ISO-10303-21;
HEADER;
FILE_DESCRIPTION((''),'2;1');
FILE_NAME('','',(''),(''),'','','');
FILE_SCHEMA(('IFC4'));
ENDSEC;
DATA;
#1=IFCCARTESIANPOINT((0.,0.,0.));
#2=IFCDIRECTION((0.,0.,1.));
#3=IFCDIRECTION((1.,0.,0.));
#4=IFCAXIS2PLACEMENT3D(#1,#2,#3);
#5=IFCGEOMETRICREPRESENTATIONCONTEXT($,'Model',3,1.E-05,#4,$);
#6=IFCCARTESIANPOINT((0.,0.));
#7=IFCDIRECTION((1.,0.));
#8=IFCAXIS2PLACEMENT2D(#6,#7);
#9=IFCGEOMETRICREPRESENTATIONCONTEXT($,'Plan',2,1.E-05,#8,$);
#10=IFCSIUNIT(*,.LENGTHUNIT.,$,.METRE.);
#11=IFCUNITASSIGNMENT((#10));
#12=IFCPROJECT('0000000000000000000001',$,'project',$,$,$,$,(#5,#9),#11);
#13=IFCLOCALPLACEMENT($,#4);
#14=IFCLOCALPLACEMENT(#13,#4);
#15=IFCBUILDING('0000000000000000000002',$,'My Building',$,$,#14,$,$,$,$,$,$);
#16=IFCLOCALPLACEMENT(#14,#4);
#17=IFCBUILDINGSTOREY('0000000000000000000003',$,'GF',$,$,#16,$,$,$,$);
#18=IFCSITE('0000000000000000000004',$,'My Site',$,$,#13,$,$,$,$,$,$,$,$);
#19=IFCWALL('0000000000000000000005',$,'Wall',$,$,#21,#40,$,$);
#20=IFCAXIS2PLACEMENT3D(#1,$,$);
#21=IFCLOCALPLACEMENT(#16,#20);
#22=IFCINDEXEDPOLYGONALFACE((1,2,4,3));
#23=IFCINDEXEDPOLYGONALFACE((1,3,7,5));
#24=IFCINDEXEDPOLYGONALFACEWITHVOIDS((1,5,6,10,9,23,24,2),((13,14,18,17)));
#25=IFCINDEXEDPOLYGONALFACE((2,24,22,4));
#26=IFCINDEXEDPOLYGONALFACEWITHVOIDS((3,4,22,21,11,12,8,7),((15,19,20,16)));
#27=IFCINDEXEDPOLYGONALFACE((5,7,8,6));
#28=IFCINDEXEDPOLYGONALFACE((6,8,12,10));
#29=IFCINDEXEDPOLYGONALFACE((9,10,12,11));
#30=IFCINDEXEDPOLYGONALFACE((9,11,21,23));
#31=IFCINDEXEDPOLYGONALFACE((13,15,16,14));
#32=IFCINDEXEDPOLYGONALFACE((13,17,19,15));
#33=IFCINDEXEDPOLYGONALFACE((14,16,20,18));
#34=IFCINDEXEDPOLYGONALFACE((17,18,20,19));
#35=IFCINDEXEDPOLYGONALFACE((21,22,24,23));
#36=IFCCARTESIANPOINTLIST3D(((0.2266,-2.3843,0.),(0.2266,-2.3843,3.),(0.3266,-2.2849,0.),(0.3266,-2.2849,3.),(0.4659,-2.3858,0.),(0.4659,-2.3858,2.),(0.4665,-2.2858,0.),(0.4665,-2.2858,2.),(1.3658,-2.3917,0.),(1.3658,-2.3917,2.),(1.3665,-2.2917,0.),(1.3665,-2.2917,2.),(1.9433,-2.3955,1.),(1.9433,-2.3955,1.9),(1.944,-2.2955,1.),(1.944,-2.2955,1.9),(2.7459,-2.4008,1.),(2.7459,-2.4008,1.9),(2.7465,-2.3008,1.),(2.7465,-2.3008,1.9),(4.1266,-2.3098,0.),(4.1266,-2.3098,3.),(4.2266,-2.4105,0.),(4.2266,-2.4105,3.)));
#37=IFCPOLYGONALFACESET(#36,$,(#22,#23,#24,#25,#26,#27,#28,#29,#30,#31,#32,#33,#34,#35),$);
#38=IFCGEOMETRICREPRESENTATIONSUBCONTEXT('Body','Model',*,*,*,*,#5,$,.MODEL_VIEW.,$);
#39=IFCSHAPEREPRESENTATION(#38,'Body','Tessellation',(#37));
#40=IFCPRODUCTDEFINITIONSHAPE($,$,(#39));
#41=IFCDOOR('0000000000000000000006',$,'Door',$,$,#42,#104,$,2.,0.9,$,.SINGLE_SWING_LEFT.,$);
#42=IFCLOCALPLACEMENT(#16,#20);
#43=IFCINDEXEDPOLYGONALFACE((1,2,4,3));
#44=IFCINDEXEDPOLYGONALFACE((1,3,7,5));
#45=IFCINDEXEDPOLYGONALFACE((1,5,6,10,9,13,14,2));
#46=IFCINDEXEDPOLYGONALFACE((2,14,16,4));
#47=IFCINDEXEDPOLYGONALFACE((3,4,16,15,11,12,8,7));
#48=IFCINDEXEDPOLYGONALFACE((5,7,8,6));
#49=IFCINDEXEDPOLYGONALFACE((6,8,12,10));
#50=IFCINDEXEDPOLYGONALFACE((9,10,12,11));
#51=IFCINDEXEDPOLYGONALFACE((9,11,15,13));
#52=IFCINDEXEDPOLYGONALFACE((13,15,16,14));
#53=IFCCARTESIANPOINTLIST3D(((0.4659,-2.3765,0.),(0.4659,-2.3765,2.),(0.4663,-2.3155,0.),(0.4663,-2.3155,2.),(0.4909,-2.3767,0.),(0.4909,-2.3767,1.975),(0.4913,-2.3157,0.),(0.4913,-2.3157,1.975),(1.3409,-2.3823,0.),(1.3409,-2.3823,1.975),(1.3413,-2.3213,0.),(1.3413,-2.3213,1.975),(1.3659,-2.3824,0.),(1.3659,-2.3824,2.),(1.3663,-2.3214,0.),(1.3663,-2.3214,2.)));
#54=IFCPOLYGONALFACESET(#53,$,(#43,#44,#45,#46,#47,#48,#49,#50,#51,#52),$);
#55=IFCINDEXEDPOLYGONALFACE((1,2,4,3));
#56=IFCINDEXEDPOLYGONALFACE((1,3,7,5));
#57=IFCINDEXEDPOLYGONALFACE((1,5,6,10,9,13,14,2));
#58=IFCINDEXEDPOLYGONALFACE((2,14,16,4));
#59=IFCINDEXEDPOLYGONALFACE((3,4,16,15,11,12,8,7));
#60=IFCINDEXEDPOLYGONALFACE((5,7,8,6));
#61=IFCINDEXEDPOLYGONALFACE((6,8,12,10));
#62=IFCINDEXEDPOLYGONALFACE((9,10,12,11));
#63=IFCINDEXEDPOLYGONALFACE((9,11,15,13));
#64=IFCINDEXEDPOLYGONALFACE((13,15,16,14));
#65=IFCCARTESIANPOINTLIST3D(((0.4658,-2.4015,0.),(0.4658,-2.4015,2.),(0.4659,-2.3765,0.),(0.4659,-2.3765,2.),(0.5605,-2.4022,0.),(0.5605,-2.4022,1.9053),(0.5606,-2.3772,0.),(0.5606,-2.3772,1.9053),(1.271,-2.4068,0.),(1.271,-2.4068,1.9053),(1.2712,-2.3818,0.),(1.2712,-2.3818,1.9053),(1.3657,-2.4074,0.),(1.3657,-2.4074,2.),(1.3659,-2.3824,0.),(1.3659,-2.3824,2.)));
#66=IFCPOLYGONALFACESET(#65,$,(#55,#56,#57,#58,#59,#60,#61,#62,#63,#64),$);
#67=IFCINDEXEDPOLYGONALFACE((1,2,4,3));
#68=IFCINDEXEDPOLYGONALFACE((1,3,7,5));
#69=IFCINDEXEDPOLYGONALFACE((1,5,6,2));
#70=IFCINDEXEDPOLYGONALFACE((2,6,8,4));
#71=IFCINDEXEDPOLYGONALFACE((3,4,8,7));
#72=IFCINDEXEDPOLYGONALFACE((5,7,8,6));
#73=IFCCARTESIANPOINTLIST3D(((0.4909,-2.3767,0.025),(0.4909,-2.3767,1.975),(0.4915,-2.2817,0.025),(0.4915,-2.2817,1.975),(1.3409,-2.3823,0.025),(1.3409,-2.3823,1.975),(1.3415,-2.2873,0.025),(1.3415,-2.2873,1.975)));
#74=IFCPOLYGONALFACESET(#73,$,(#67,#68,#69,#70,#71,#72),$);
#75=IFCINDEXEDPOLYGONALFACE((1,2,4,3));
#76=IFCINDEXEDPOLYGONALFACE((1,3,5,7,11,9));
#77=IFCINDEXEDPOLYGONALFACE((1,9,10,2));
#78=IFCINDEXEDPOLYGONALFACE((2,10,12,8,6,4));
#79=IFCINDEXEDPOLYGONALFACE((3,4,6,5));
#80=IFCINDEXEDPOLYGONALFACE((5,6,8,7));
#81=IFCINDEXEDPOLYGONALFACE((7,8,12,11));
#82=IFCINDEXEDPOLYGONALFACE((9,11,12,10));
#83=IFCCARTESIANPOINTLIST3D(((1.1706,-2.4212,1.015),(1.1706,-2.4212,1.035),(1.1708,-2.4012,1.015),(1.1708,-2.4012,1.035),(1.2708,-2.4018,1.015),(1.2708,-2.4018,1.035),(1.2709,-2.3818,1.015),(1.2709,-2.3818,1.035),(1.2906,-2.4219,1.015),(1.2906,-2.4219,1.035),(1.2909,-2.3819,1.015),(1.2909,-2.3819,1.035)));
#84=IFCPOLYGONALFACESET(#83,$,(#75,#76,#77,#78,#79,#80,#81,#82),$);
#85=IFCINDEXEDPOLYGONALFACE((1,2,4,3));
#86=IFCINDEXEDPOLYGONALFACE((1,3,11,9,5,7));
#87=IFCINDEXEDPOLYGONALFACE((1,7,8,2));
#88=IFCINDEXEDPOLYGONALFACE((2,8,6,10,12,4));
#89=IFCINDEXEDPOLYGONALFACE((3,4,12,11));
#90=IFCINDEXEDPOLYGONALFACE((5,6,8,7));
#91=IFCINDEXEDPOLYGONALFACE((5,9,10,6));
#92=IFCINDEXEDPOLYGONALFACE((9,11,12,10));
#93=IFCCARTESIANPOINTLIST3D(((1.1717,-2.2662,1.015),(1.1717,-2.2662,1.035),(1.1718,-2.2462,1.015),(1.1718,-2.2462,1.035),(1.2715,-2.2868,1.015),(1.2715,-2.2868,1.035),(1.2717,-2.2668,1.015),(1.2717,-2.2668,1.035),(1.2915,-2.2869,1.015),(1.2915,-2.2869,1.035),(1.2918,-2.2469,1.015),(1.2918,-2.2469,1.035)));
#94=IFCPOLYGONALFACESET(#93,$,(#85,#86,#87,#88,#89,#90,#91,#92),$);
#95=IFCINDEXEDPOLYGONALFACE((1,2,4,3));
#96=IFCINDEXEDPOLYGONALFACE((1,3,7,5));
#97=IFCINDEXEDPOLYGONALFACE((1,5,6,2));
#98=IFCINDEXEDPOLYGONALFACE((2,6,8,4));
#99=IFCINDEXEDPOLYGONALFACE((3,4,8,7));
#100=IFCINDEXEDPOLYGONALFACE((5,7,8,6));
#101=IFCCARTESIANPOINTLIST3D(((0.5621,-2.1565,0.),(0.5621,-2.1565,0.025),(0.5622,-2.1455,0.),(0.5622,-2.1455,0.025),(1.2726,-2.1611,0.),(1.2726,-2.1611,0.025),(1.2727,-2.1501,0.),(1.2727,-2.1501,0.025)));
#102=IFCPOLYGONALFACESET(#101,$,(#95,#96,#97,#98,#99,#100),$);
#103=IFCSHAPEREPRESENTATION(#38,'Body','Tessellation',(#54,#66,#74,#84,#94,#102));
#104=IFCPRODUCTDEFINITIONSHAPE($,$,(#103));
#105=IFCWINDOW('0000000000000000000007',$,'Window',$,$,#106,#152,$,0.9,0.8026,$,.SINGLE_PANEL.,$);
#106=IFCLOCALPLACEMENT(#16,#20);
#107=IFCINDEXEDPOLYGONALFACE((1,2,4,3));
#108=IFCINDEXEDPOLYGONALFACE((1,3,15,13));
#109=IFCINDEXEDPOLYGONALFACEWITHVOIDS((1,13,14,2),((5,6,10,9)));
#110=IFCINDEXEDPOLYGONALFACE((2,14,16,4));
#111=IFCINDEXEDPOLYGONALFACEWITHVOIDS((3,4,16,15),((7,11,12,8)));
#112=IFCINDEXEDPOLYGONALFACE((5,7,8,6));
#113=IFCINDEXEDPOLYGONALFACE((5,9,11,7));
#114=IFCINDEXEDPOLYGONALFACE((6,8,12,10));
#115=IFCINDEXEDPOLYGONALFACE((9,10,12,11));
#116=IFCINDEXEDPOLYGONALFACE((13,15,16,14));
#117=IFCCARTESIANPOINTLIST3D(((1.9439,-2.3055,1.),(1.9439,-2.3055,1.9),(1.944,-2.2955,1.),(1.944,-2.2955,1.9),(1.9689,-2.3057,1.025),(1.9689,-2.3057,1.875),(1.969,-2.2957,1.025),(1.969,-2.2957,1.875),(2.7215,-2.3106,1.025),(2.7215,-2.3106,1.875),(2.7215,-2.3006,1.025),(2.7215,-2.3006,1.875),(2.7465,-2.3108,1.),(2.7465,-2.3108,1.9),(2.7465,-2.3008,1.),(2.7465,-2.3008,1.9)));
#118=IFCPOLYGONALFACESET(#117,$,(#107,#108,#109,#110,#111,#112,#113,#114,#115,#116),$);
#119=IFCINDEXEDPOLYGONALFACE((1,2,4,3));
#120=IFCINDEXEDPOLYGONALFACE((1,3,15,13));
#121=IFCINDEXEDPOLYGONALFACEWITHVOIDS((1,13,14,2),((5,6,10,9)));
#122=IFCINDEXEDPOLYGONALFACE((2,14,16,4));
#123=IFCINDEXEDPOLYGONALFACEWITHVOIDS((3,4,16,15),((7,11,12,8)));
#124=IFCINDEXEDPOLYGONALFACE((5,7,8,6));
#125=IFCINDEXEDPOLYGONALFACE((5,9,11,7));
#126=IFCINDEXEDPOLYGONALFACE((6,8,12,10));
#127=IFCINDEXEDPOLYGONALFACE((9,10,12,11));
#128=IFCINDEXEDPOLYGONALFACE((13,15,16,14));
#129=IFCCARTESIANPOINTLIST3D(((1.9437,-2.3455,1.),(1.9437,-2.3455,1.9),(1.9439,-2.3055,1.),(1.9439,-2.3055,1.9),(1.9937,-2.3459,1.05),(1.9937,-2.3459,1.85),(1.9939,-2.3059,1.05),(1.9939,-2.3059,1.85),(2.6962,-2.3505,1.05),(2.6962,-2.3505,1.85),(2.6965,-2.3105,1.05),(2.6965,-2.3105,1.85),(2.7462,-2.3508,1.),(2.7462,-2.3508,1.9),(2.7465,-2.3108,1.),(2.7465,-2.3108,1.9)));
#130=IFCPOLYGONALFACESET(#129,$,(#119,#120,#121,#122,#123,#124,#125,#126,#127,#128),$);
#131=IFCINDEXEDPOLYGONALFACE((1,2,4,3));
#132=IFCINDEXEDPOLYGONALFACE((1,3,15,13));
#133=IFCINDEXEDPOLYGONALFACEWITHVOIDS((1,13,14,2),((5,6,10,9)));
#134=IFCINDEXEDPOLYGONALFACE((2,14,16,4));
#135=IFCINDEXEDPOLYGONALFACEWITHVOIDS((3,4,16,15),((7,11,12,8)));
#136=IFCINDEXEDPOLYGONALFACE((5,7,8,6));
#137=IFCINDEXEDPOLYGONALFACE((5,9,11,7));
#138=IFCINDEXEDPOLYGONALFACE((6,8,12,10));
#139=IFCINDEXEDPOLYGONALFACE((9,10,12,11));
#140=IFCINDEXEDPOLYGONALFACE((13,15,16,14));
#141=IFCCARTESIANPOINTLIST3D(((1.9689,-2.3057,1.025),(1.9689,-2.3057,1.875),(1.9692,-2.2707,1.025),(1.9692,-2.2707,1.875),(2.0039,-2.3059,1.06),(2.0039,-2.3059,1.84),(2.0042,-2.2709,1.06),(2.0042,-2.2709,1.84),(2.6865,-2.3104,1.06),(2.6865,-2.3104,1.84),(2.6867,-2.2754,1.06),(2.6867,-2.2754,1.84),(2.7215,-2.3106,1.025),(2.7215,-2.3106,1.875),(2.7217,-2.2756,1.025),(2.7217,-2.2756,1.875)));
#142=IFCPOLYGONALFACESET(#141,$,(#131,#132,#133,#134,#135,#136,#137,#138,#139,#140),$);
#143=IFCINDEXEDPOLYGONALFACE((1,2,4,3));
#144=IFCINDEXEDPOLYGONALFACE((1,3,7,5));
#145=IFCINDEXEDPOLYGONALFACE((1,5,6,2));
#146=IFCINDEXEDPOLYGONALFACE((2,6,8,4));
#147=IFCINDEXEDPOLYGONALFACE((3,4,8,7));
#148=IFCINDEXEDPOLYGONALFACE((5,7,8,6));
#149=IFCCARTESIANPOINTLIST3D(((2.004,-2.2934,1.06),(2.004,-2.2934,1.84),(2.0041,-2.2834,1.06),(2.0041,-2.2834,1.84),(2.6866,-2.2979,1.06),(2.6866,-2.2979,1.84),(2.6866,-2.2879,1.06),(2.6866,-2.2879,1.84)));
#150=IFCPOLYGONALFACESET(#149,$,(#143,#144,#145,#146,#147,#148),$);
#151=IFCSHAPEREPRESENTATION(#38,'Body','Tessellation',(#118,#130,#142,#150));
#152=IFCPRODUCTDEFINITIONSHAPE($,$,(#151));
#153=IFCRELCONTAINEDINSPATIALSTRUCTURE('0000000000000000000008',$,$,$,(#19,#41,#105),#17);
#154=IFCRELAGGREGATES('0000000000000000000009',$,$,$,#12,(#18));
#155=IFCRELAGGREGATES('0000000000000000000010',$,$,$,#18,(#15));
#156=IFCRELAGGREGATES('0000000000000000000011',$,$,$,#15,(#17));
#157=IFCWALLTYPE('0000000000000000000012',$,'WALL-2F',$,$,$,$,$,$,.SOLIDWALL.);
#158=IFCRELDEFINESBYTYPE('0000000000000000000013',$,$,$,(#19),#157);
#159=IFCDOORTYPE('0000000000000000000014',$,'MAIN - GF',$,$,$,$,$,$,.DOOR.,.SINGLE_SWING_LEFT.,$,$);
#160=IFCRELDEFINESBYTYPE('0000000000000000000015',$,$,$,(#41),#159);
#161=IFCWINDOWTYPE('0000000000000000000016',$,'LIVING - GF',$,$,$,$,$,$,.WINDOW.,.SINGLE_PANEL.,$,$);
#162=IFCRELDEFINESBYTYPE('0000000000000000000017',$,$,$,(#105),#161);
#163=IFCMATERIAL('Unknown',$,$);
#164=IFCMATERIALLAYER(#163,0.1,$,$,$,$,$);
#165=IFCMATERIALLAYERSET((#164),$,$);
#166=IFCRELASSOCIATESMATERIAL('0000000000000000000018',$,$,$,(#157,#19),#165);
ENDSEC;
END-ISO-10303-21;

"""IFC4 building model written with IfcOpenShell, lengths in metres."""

from ifc_helpers import new_model, entity, si_unit, frame, origin_with_axes, origin_2d_with_axis, place, context, subcontext, project, spatial, line, indexed_curve, outline, extrude, shape, source, transform, mapped, material, layer, layer_set, layer_usage, type_object, type_shapes, element, fill, save


model = new_model("IFC4")

# Units and contexts
model_context = context("Model", 3, precision=1e-05, world=origin_with_axes())
plan_context = context("Plan", 2, precision=1e-05, world=origin_2d_with_axis())
body_context_1 = subcontext(model_context, "Body", "Model", "MODEL_VIEW")
body_context_2 = subcontext(plan_context, "Body", "Plan", "PLAN_VIEW")
ifc_project = project(units=[si_unit("LENGTHUNIT", "METRE")], contexts=[model_context, plan_context])

# Site, building, storey
site_placement = place(None, origin_with_axes())
site = spatial("IfcSite", under=ifc_project, at=site_placement, Name="My Site")
building_placement = place(site_placement, origin_with_axes())
building = spatial("IfcBuilding", under=site, at=building_placement, Name="My Building")
storey_placement = place(building_placement, origin_with_axes())
storey = spatial("IfcBuildingStorey", under=building, at=storey_placement, Name="GF")

# Shared definitions
ifc_material = material(Name="Unknown")

# Shared definitions
ifc_layer_1 = layer(ifc_material, 0.1)
ifc_layer_set_1 = layer_set([ifc_layer_1])
wall_type = type_object("IfcWallType", Name="WALL-2F", PredefinedType="SOLIDWALL", material=ifc_layer_set_1)

# Wall, openings, door, window
ifc_layer_usage_1 = layer_usage(ifc_layer_set_1, "AXIS2", "POSITIVE", 0.0)
wall_1_placement = place(storey_placement, frame((0.2266, -2.3843, 0.0), z_axis=(0.0, 0.0, 1.0), x_axis=(0.999979, -0.006552, 0.0)))
wall_1 = element("IfcWall", 1, at=wall_1_placement, inside=storey, type_object=wall_type, material=ifc_layer_usage_1, Name="Wall", context=body_context_1, shape_type="SweptSolid", body=[
    extrude(outline(indexed_curve([(0.0, 0.0), (0.0993, 0.1), (3.8994, 0.1), (4.0001, 0.0)], segments=[line(1, 2, 3, 4, 1)])), origin_with_axes(), (0.0, 0.0, 1.0), 3.0),
])
shared_shape_1 = source(origin_with_axes(), body_context_1, "Body", "SweptSolid", [
    extrude(outline(indexed_curve([(0.0, 0.0), (0.9, 0.0), (0.9, 2.0), (0.0, 2.0)], segments=[line(1, 2, 3, 4, 1)])), frame((0.0, -0.6, 0.0), z_axis=(0.0, -1.0, 0.0), x_axis=(1.0, 0.0, 0.0)), (0.0, 0.0, -1.0), 1.2),
])
opening_1_placement = place(wall_1_placement, frame((0.2393, 0.0, 0.0), z_axis=(0.0, 0.0, 1.0), x_axis=(1.0, 0.0, 0.0)))
opening_1 = element("IfcOpeningElement", 2, at=opening_1_placement, cuts=wall_1, PredefinedType="OPENING", context=body_context_1, shape_type="MappedRepresentation", body=[
    mapped(shared_shape_1, transform((0.0, 0.0, 0.0), x_axis=(1.0, 0.0, 0.0), y_axis=(0.0, 1.0, 0.0), z_axis=(0.0, 0.0, 1.0), scale=1.0)),
])
shared_shape_2 = source(origin_with_axes(), body_context_1, "Body", "SweptSolid", [
    extrude(outline(indexed_curve([(0.0, 0.0), (0.8026, 0.0), (0.8026, 0.9), (0.0, 0.9)], segments=[line(1, 2, 3, 4, 1)])), frame((0.0, -0.6, 0.0), z_axis=(0.0, -1.0, 0.0), x_axis=(1.0, 0.0, 0.0)), (0.0, 0.0, -1.0), 1.2),
])
opening_2_placement = place(wall_1_placement, frame((1.7168, 0.0, 1.0), z_axis=(0.0, 0.0, 1.0), x_axis=(1.0, 0.0, 0.0)))
opening_2 = element("IfcOpeningElement", 3, at=opening_2_placement, cuts=wall_1, PredefinedType="OPENING", context=body_context_1, shape_type="MappedRepresentation", body=[
    mapped(shared_shape_2, transform((0.0, 0.0, 0.0), x_axis=(1.0, 0.0, 0.0), y_axis=(0.0, 1.0, 0.0), z_axis=(0.0, 0.0, 1.0), scale=1.0)),
])
door_type_1 = type_object("IfcDoorType", Name="MAIN - GF", OperationType="SINGLE_SWING_LEFT", PredefinedType="DOOR")
shared_shape_3 = source(origin_with_axes(), body_context_1, "Body", "SweptSolid", [
    extrude(outline(indexed_curve([(0.0, 0.0), (0.0, 2.0), (0.9, 2.0), (0.9, 0.0), (0.875, 0.0), (0.875, 1.975), (0.025, 1.975), (0.025, 0.0)], segments=[line(1, 2, 3, 4, 5, 6, 7, 8, 1)])), frame((0.0, 0.0093, 0.0), z_axis=(0.0, -1.0, 0.0), x_axis=(1.0, 0.0, 0.0)), (0.0, 0.0, -1.0), 0.061),
    extrude(outline(indexed_curve([(0.0, 0.0), (0.0, 2.0), (0.9, 2.0), (0.9, 0.0), (0.8053, 0.0), (0.8053, 1.9053), (0.0947, 1.9053), (0.0947, 0.0)], segments=[line(1, 2, 3, 4, 5, 6, 7, 8, 1)])), frame((0.0, -0.0157, 0.0), z_axis=(0.0, -1.0, 0.0), x_axis=(1.0, 0.0, 0.0)), (0.0, 0.0, -1.0), 0.025),
    extrude(outline(indexed_curve([(0.0, 0.0), (0.85, 0.0), (0.85, 0.095), (0.0, 0.095)], segments=[line(1, 2, 3, 4, 1)])), frame((0.025, 0.0093, 0.025), z_axis=(0.0, 0.0, 1.0), x_axis=(1.0, 0.0, 0.0)), (0.0, 0.0, 1.0), 1.95),
    extrude(outline(indexed_curve([(0.0, 0.0), (0.0, -0.04), (-0.12, -0.04), (-0.12, -0.02), (-0.02, -0.02), (-0.02, 0.0)], segments=[line(1, 2, 3, 4, 5, 6, 1)])), frame((0.825, 0.0093, 1.015), z_axis=(0.0, 0.0, 1.0), x_axis=(1.0, 0.0, 0.0)), (0.0, 0.0, 1.0), 0.02),
    extrude(outline(indexed_curve([(0.0, 0.0), (0.0, 0.04), (-0.12, 0.04), (-0.12, 0.02), (-0.02, 0.02), (-0.02, 0.0)], segments=[line(1, 2, 3, 4, 5, 6, 1)])), frame((0.825, 0.1043, 1.015), z_axis=(0.0, 0.0, 1.0), x_axis=(1.0, 0.0, 0.0)), (0.0, 0.0, 1.0), 0.02),
    extrude(outline(indexed_curve([(0.0, 0.0), (0.7105, 0.0), (0.7105, 0.011), (0.0, 0.011)], segments=[line(1, 2, 3, 4, 1)])), frame((0.0947, 0.23, 0.0), z_axis=(0.0, 0.0, 1.0), x_axis=(1.0, 0.0, 0.0)), (0.0, 0.0, 1.0), 0.025),
])
shared_shape_4 = source(origin_with_axes(), body_context_2, "Body", "Curve2D", [
    entity("IfcIndexedPolyCurve", entity("IfcCartesianPointList2D", [[0.0, -0.0157], [0.0, 0.0703], [0.025, 0.0703], [0.025, 0.0093], [0.0947, 0.0093], [0.0947, -0.0157]]), [entity("IfcLineIndex", [1, 2, 3, 4, 5, 6, 1])]),
    entity("IfcIndexedPolyCurve", entity("IfcCartesianPointList2D", [[0.9, -0.0157], [0.9, 0.0703], [0.875, 0.0703], [0.875, 0.0093], [0.8053, 0.0093], [0.8053, -0.0157]]), [entity("IfcLineIndex", [1, 2, 3, 4, 5, 6, 1])]),
    entity("IfcTrimmedCurve", entity("IfcEllipse", entity("IfcAxis2Placement2D", entity("IfcCartesianPoint", [0.12, 0.0703]), entity("IfcDirection", [1.0, 0.0])), 0.755, 0.85), [entity("IfcCartesianPoint", [0.875, 0.0703])], [entity("IfcCartesianPoint", [0.12, 0.9203])], True, "CARTESIAN"),
    entity("IfcIndexedPolyCurve", entity("IfcCartesianPointList2D", [[0.025, 0.0703], [0.12, 0.0703], [0.12, 0.9203], [0.025, 0.9203]]), [entity("IfcLineIndex", [1, 2, 3, 4, 1])]),
])
type_shapes(door_type_1, [shared_shape_3, shared_shape_4])
door_1_placement = place(opening_1_placement, frame((0.0, 0.0, 0.0), z_axis=(0.0, 0.0, 1.0), x_axis=(1.0, 0.0, 0.0)))
door_1 = element("IfcDoor", 4, at=door_1_placement, inside=storey, type_object=door_type_1, Name="Door", OperationType="SINGLE_SWING_LEFT", OverallHeight=2.0, OverallWidth=0.9, shapes=[
    shape(body_context_1, "Body", "MappedRepresentation", [mapped(shared_shape_3, transform((0.0, 0.0, 0.0), x_axis=(1.0, 0.0, 0.0), y_axis=(0.0, 1.0, 0.0), z_axis=(0.0, 0.0, 1.0), scale=1.0))]),
    shape(body_context_2, "Body", "MappedRepresentation", [mapped(shared_shape_4, transform((0.0, 0.0, 0.0), x_axis=(1.0, 0.0, 0.0), y_axis=(0.0, 1.0, 0.0), z_axis=(0.0, 0.0, 1.0), scale=1.0))]),
])
fill(opening_1, door_1)
window_type_1 = type_object("IfcWindowType", Name="LIVING - GF", PartitioningType="SINGLE_PANEL", PredefinedType="WINDOW")
shared_shape_5 = source(origin_with_axes(), body_context_1, "Body", "SweptSolid", [
    extrude(outline(indexed_curve([(0.0, 0.0), (0.8026, 0.0), (0.8026, 0.9), (0.0, 0.9)], segments=[line(1, 2, 3, 4, 1)]), holes=[indexed_curve([(0.025, 0.025), (0.7776, 0.025), (0.7776, 0.875), (0.025, 0.875)], segments=[line(1, 2, 3, 4, 1)])]), frame((0.0, 0.09, 0.0), z_axis=(0.0, -1.0, 0.0), x_axis=(1.0, 0.0, 0.0)), (0.0, 0.0, -1.0), 0.01),
    extrude(outline(indexed_curve([(0.0, 0.0), (0.8026, 0.0), (0.8026, 0.9), (0.0, 0.9)], segments=[line(1, 2, 3, 4, 1)]), holes=[indexed_curve([(0.05, 0.05), (0.7526, 0.05), (0.7526, 0.85), (0.05, 0.85)], segments=[line(1, 2, 3, 4, 1)])]), frame((0.0, 0.05, 0.0), z_axis=(0.0, -1.0, 0.0), x_axis=(1.0, 0.0, 0.0)), (0.0, 0.0, -1.0), 0.04),
    extrude(outline(indexed_curve([(0.0, 0.0), (0.7526, 0.0), (0.7526, 0.85), (0.0, 0.85)], segments=[line(1, 2, 3, 4, 1)]), holes=[indexed_curve([(0.035, 0.035), (0.7176, 0.035), (0.7176, 0.815), (0.035, 0.815)], segments=[line(1, 2, 3, 4, 1)])]), frame((0.025, 0.09, 0.025), z_axis=(0.0, -1.0, 0.0), x_axis=(1.0, 0.0, 0.0)), (0.0, 0.0, -1.0), 0.035),
    extrude(outline(indexed_curve([(0.035, 0.035), (0.7176, 0.035), (0.7176, 0.815), (0.035, 0.815)], segments=[line(1, 2, 3, 4, 1)])), frame((0.025, 0.1025, 0.025), z_axis=(0.0, -1.0, 0.0), x_axis=(1.0, 0.0, 0.0)), (0.0, 0.0, -1.0), 0.01),
])
shared_shape_6 = source(origin_with_axes(), body_context_2, "Body", "Curve2D", [
    entity("IfcIndexedPolyCurve", entity("IfcCartesianPointList2D", [[0.05, 0.05], [0.7526, 0.05]])),
    entity("IfcIndexedPolyCurve", entity("IfcCartesianPointList2D", [[0.0, 0.1], [0.025, 0.1], [0.025, 0.09], [0.05, 0.09], [0.05, 0.05], [0.0, 0.05]]), [entity("IfcLineIndex", [1, 2, 3, 4, 5, 6, 1])]),
    entity("IfcIndexedPolyCurve", entity("IfcCartesianPointList2D", [[0.8026, 0.1], [0.7776, 0.1], [0.7776, 0.09], [0.7526, 0.09], [0.7526, 0.05], [0.8026, 0.05]]), [entity("IfcLineIndex", [1, 2, 3, 4, 5, 6, 1])]),
    entity("IfcIndexedPolyCurve", entity("IfcCartesianPointList2D", [[0.025, 0.09], [0.06, 0.09], [0.06, 0.125], [0.025, 0.125]]), [entity("IfcLineIndex", [1, 2, 3, 4, 1])]),
    entity("IfcIndexedPolyCurve", entity("IfcCartesianPointList2D", [[0.7776, 0.09], [0.7426, 0.09], [0.7426, 0.125], [0.7776, 0.125]]), [entity("IfcLineIndex", [1, 2, 3, 4, 1])]),
    entity("IfcIndexedPolyCurve", entity("IfcCartesianPointList2D", [[0.06, 0.09], [0.7426, 0.09]])),
    entity("IfcIndexedPolyCurve", entity("IfcCartesianPointList2D", [[0.06, 0.125], [0.7426, 0.125]])),
    entity("IfcIndexedPolyCurve", entity("IfcCartesianPointList2D", [[0.06, 0.1075], [0.7426, 0.1075]])),
])
type_shapes(window_type_1, [shared_shape_5, shared_shape_6])
window_1_placement = place(opening_2_placement, frame((0.0, 0.0, 0.0), z_axis=(0.0, 0.0, 1.0), x_axis=(1.0, 0.0, 0.0)))
window_1 = element("IfcWindow", 5, at=window_1_placement, inside=storey, type_object=window_type_1, Name="Window", OverallHeight=0.9, OverallWidth=0.8026, PartitioningType="SINGLE_PANEL", shapes=[
    shape(body_context_1, "Body", "MappedRepresentation", [mapped(shared_shape_5, transform((0.0, 0.0, 0.0), x_axis=(1.0, 0.0, 0.0), y_axis=(0.0, 1.0, 0.0), z_axis=(0.0, 0.0, 1.0), scale=1.0))]),
    shape(body_context_2, "Body", "MappedRepresentation", [mapped(shared_shape_6, transform((0.0, 0.0, 0.0), x_axis=(1.0, 0.0, 0.0), y_axis=(0.0, 1.0, 0.0), z_axis=(0.0, 0.0, 1.0), scale=1.0))]),
])
fill(opening_2, window_1)

save(model, "model.ifc")
